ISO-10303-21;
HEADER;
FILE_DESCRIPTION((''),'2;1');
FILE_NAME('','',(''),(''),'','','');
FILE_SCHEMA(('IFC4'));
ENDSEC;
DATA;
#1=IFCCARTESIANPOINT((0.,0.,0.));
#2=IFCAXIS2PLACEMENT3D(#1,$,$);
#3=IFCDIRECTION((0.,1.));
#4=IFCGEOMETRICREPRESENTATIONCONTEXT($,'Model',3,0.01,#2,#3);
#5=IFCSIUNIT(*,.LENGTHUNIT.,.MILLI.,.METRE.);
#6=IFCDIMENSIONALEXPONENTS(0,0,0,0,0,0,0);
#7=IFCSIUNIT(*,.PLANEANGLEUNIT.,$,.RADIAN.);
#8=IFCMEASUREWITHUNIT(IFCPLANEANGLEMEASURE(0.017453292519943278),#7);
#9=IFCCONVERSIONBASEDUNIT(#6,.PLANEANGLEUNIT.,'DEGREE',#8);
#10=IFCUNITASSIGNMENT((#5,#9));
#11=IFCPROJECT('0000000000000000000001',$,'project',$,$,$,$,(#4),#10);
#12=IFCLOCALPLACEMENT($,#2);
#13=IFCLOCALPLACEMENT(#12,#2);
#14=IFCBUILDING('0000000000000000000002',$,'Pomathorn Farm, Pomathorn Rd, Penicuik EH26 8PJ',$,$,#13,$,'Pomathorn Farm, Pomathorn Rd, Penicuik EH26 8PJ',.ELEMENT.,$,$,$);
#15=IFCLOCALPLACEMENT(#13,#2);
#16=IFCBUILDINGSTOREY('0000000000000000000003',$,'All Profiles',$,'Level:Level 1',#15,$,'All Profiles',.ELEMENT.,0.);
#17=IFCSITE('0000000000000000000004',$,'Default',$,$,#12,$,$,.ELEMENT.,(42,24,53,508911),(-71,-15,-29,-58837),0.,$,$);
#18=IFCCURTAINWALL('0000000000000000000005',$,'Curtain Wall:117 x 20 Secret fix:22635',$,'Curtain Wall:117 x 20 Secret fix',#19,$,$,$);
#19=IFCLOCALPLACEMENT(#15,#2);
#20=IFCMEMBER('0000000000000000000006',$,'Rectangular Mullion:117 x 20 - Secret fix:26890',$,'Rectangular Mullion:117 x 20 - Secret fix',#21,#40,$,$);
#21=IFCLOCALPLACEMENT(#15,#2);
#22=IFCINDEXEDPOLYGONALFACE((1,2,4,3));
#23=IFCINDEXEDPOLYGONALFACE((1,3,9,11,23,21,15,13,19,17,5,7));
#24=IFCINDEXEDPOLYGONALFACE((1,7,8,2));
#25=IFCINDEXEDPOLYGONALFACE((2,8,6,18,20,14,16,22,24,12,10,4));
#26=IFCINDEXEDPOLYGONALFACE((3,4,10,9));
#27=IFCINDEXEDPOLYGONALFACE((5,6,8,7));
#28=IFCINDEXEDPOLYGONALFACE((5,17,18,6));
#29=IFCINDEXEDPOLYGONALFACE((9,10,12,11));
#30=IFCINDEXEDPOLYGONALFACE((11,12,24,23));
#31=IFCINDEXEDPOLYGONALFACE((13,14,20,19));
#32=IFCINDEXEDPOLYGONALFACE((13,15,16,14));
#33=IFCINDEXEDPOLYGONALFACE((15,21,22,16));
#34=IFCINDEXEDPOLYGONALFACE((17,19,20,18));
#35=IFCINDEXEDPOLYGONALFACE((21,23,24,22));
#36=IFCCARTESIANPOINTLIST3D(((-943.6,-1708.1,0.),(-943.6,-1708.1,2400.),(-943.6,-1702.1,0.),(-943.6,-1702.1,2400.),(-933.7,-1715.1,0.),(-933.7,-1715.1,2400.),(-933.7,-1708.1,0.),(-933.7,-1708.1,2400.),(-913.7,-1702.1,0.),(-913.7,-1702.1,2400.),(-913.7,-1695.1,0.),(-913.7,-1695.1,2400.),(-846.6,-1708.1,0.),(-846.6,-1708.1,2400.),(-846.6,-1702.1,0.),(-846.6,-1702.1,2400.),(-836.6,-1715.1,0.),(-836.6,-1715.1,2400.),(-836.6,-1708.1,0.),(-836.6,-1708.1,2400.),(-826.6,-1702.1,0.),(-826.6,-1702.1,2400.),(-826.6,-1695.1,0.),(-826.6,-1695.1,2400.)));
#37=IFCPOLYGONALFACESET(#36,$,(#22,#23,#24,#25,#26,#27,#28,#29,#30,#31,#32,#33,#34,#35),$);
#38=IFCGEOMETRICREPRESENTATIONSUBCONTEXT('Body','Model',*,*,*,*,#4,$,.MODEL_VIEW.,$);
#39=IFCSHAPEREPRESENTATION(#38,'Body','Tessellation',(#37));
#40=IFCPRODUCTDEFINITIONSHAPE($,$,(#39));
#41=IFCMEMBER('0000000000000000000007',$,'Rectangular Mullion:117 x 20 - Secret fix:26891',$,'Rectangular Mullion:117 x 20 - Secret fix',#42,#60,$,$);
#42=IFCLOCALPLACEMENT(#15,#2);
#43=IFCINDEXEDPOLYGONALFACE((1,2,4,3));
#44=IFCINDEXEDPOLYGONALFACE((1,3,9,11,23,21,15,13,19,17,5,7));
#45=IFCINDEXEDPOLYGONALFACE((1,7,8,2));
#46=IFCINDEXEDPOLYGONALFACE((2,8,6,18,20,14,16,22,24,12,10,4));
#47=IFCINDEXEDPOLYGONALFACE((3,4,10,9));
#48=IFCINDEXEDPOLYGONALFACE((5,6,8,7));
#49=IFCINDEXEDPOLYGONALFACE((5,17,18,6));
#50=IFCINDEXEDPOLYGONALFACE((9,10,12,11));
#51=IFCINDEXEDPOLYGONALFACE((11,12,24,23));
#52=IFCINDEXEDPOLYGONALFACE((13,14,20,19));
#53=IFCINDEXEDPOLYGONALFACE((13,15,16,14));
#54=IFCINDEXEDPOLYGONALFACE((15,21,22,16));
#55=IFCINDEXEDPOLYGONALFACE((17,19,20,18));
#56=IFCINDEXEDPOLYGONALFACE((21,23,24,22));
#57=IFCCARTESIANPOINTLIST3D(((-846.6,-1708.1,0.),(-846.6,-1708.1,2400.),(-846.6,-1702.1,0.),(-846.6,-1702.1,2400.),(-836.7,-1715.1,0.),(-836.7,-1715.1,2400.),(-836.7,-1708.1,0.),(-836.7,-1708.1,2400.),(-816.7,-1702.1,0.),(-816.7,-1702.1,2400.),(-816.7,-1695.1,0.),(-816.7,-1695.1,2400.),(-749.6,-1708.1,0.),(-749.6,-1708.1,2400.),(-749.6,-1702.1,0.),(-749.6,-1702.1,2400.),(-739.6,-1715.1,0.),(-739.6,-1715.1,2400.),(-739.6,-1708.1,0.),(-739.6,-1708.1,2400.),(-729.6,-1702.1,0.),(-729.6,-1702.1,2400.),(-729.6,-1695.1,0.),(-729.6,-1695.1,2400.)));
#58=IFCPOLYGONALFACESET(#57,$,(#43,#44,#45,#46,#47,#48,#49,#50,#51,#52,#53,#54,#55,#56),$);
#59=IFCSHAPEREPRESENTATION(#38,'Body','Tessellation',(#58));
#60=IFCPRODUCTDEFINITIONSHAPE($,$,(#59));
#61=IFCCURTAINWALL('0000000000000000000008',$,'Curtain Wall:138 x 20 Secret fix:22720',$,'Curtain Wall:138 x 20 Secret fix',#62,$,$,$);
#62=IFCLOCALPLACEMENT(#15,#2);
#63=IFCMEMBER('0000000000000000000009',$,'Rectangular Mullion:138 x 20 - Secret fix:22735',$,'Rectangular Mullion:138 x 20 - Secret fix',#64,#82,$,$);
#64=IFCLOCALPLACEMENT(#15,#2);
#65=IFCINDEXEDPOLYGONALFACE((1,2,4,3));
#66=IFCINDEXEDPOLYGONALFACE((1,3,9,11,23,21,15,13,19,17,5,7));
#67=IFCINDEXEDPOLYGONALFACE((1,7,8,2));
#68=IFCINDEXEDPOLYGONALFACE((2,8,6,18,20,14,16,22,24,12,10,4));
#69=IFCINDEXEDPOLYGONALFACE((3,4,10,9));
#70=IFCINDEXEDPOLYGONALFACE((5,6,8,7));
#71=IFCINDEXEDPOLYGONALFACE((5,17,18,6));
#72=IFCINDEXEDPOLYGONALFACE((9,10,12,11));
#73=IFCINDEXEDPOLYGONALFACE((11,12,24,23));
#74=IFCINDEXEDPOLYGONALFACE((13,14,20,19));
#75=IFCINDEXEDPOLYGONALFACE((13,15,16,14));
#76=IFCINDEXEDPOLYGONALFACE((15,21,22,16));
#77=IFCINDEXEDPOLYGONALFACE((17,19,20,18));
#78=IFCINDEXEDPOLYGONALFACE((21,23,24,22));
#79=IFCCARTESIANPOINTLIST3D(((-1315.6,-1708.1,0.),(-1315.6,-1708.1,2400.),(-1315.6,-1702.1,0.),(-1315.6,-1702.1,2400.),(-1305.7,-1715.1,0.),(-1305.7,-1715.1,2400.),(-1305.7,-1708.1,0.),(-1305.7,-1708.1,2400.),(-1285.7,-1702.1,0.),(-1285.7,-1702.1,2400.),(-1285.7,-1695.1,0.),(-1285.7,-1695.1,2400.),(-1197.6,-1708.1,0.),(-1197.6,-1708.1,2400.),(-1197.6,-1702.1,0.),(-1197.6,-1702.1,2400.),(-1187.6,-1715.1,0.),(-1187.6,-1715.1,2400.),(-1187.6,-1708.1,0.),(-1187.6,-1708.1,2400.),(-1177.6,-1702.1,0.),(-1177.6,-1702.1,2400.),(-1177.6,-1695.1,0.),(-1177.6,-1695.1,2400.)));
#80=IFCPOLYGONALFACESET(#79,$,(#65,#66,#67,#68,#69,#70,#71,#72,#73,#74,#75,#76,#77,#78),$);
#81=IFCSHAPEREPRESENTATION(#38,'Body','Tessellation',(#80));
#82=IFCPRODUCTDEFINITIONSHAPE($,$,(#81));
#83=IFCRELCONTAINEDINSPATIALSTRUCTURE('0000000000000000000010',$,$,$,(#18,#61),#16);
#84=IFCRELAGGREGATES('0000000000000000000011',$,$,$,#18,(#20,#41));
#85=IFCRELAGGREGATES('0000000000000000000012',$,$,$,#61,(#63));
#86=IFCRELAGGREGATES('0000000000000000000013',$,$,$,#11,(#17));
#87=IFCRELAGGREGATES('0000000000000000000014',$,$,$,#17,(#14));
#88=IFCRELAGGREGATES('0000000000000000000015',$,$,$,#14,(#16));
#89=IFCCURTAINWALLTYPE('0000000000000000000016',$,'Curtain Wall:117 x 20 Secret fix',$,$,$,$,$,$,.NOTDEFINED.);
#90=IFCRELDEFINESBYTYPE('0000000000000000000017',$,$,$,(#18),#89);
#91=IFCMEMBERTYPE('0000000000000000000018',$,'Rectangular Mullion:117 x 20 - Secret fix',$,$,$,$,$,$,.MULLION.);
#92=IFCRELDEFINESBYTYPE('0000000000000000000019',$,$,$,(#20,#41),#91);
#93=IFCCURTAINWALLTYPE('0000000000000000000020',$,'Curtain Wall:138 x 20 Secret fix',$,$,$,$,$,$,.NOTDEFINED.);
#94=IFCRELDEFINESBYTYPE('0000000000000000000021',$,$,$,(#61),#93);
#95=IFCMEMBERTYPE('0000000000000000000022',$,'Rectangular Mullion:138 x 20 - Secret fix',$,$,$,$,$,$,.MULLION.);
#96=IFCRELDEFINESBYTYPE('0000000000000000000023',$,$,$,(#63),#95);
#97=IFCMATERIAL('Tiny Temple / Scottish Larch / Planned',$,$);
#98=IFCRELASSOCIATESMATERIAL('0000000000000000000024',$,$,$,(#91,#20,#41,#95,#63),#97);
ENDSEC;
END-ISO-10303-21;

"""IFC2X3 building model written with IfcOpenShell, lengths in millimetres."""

from ifc_helpers import new_model, entity, si_unit, converted_unit, direction, frame, origin, place, context, subcontext, project, spatial, polyline, outline, extrude, source, transform, mapped, material, type_object, type_shapes, element, aggregate, save


model = new_model("IFC2X3")

# Units and contexts
model_context = context("Model", 3, precision=0.01, world=origin(), true_north=direction((0.0, 1.0)))
body_context = subcontext(model_context, "Body", "Model", "MODEL_VIEW")
ifc_project = project(units=[si_unit("LENGTHUNIT", "METRE", prefix="MILLI"), converted_unit("PLANEANGLEUNIT", "DEGREE", entity("IfcPlaneAngleMeasure", 0.017453292519943278), si_unit("PLANEANGLEUNIT", "RADIAN"), dimensions=[0, 0, 0, 0, 0, 0, 0])], contexts=[model_context])

# Site, building, storey
site_placement = place(None, origin())
site = spatial("IfcSite", under=ifc_project, at=site_placement, Name="Default", CompositionType="ELEMENT", RefLatitude=(42, 24, 53, 508911), RefLongitude=(-71, -15, -29, -58837), RefElevation=0.0)
building_placement = place(site_placement, origin())
building = spatial("IfcBuilding", under=site, at=building_placement, Name="Pomathorn Farm, Pomathorn Rd, Penicuik EH26 8PJ", LongName="Pomathorn Farm, Pomathorn Rd, Penicuik EH26 8PJ", CompositionType="ELEMENT")
storey_placement = place(building_placement, origin())
storey = spatial("IfcBuildingStorey", under=building, at=storey_placement, Name="All Profiles", ObjectType="Level:Level 1", LongName="All Profiles", CompositionType="ELEMENT", Elevation=0.0)

# Curtain wall, members
curtain_wall_type_1 = type_object("IfcCurtainWallType", Name="Curtain Wall:117 x 20 Secret fix", PredefinedType="NOTDEFINED")
curtain_wall_1_placement = place(storey_placement, origin())
curtain_wall_1 = element("IfcCurtainWall", 1, at=curtain_wall_1_placement, inside=storey, type_object=curtain_wall_type_1, Name="Curtain Wall:117 x 20 Secret fix:22635", ObjectType="Curtain Wall:117 x 20 Secret fix")
ifc_material = material(Name="Tiny Temple / Scottish Larch / Planned")
member_type_1 = type_object("IfcMemberType", Name="Rectangular Mullion:117 x 20 - Secret fix", PredefinedType="MULLION", material=ifc_material)
shared_shape_1 = source(origin(), body_context, "Body", "SweptSolid", [
    extrude(outline(polyline([(-3.0, -60.2), (3.0, -60.2), (3.0, -30.2), (10.0, -30.2), (10.0, 56.8), (3.0, 56.8), (3.0, 36.8), (-3.0, 36.8), (-3.0, 46.8), (-10.0, 46.8), (-10.0, -50.2), (-3.0, -50.2), (-3.0, -60.2)])), frame((-56.8, -10.0, -2400.0), z_axis=(0.0, 0.0, 1.0), x_axis=(0.0, -1.0, 0.0)), (0.0, 0.0, 1.0), 2400.0),
])
type_shapes(member_type_1, [shared_shape_1])
member_1_placement = place(curtain_wall_1_placement, frame((-826.6, -1715.1, 0.0), z_axis=(0.0, 0.0, -1.0), x_axis=(1.0, 0.0, 0.0)))
member_1 = element("IfcMember", 2, at=member_1_placement, type_object=member_type_1, material=ifc_material, Name="Rectangular Mullion:117 x 20 - Secret fix:26890", ObjectType="Rectangular Mullion:117 x 20 - Secret fix", context=body_context, shape_type="MappedRepresentation", body=[
    mapped(shared_shape_1, transform((0.0, 0.0, 0.0), scale=1.0)),
])
member_2_placement = place(curtain_wall_1_placement, frame((-729.6, -1715.1, 0.0), z_axis=(0.0, 0.0, -1.0), x_axis=(1.0, 0.0, 0.0)))
member_2 = element("IfcMember", 3, at=member_2_placement, type_object=member_type_1, material=ifc_material, Name="Rectangular Mullion:117 x 20 - Secret fix:26891", ObjectType="Rectangular Mullion:117 x 20 - Secret fix", context=body_context, shape_type="MappedRepresentation", body=[
    mapped(shared_shape_1, transform((0.0, 0.0, 0.0), scale=1.0)),
])
aggregate(curtain_wall_1, [member_1, member_2])

# Curtain wall, member
curtain_wall_type_2 = type_object("IfcCurtainWallType", Name="Curtain Wall:138 x 20 Secret fix", PredefinedType="NOTDEFINED")
curtain_wall_2_placement = place(storey_placement, origin())
curtain_wall_2 = element("IfcCurtainWall", 4, at=curtain_wall_2_placement, inside=storey, type_object=curtain_wall_type_2, Name="Curtain Wall:138 x 20 Secret fix:22720", ObjectType="Curtain Wall:138 x 20 Secret fix")
member_type_2 = type_object("IfcMemberType", Name="Rectangular Mullion:138 x 20 - Secret fix", PredefinedType="MULLION", material=ifc_material)
shared_shape_2 = source(origin(), body_context, "Body", "SweptSolid", [
    extrude(outline(polyline([(-3.0, -70.7), (3.0, -70.7), (3.0, -40.7), (10.0, -40.7), (10.0, 67.3), (3.0, 67.3), (3.0, 47.3), (-3.0, 47.3), (-3.0, 57.3), (-10.0, 57.3), (-10.0, -60.7), (-3.0, -60.7), (-3.0, -70.7)])), frame((-67.3, -10.0, -2400.0), z_axis=(0.0, 0.0, 1.0), x_axis=(0.0, -1.0, 0.0)), (0.0, 0.0, 1.0), 2400.0),
])
type_shapes(member_type_2, [shared_shape_2])
member_3_placement = place(curtain_wall_2_placement, frame((-1177.6, -1715.1, 0.0), z_axis=(0.0, 0.0, -1.0), x_axis=(1.0, 0.0, 0.0)))
member_3 = element("IfcMember", 5, at=member_3_placement, type_object=member_type_2, material=ifc_material, Name="Rectangular Mullion:138 x 20 - Secret fix:22735", ObjectType="Rectangular Mullion:138 x 20 - Secret fix", context=body_context, shape_type="MappedRepresentation", body=[
    mapped(shared_shape_2, transform((0.0, 0.0, 0.0), scale=1.0)),
])
aggregate(curtain_wall_2, [member_3])

save(model, "model.ifc")
